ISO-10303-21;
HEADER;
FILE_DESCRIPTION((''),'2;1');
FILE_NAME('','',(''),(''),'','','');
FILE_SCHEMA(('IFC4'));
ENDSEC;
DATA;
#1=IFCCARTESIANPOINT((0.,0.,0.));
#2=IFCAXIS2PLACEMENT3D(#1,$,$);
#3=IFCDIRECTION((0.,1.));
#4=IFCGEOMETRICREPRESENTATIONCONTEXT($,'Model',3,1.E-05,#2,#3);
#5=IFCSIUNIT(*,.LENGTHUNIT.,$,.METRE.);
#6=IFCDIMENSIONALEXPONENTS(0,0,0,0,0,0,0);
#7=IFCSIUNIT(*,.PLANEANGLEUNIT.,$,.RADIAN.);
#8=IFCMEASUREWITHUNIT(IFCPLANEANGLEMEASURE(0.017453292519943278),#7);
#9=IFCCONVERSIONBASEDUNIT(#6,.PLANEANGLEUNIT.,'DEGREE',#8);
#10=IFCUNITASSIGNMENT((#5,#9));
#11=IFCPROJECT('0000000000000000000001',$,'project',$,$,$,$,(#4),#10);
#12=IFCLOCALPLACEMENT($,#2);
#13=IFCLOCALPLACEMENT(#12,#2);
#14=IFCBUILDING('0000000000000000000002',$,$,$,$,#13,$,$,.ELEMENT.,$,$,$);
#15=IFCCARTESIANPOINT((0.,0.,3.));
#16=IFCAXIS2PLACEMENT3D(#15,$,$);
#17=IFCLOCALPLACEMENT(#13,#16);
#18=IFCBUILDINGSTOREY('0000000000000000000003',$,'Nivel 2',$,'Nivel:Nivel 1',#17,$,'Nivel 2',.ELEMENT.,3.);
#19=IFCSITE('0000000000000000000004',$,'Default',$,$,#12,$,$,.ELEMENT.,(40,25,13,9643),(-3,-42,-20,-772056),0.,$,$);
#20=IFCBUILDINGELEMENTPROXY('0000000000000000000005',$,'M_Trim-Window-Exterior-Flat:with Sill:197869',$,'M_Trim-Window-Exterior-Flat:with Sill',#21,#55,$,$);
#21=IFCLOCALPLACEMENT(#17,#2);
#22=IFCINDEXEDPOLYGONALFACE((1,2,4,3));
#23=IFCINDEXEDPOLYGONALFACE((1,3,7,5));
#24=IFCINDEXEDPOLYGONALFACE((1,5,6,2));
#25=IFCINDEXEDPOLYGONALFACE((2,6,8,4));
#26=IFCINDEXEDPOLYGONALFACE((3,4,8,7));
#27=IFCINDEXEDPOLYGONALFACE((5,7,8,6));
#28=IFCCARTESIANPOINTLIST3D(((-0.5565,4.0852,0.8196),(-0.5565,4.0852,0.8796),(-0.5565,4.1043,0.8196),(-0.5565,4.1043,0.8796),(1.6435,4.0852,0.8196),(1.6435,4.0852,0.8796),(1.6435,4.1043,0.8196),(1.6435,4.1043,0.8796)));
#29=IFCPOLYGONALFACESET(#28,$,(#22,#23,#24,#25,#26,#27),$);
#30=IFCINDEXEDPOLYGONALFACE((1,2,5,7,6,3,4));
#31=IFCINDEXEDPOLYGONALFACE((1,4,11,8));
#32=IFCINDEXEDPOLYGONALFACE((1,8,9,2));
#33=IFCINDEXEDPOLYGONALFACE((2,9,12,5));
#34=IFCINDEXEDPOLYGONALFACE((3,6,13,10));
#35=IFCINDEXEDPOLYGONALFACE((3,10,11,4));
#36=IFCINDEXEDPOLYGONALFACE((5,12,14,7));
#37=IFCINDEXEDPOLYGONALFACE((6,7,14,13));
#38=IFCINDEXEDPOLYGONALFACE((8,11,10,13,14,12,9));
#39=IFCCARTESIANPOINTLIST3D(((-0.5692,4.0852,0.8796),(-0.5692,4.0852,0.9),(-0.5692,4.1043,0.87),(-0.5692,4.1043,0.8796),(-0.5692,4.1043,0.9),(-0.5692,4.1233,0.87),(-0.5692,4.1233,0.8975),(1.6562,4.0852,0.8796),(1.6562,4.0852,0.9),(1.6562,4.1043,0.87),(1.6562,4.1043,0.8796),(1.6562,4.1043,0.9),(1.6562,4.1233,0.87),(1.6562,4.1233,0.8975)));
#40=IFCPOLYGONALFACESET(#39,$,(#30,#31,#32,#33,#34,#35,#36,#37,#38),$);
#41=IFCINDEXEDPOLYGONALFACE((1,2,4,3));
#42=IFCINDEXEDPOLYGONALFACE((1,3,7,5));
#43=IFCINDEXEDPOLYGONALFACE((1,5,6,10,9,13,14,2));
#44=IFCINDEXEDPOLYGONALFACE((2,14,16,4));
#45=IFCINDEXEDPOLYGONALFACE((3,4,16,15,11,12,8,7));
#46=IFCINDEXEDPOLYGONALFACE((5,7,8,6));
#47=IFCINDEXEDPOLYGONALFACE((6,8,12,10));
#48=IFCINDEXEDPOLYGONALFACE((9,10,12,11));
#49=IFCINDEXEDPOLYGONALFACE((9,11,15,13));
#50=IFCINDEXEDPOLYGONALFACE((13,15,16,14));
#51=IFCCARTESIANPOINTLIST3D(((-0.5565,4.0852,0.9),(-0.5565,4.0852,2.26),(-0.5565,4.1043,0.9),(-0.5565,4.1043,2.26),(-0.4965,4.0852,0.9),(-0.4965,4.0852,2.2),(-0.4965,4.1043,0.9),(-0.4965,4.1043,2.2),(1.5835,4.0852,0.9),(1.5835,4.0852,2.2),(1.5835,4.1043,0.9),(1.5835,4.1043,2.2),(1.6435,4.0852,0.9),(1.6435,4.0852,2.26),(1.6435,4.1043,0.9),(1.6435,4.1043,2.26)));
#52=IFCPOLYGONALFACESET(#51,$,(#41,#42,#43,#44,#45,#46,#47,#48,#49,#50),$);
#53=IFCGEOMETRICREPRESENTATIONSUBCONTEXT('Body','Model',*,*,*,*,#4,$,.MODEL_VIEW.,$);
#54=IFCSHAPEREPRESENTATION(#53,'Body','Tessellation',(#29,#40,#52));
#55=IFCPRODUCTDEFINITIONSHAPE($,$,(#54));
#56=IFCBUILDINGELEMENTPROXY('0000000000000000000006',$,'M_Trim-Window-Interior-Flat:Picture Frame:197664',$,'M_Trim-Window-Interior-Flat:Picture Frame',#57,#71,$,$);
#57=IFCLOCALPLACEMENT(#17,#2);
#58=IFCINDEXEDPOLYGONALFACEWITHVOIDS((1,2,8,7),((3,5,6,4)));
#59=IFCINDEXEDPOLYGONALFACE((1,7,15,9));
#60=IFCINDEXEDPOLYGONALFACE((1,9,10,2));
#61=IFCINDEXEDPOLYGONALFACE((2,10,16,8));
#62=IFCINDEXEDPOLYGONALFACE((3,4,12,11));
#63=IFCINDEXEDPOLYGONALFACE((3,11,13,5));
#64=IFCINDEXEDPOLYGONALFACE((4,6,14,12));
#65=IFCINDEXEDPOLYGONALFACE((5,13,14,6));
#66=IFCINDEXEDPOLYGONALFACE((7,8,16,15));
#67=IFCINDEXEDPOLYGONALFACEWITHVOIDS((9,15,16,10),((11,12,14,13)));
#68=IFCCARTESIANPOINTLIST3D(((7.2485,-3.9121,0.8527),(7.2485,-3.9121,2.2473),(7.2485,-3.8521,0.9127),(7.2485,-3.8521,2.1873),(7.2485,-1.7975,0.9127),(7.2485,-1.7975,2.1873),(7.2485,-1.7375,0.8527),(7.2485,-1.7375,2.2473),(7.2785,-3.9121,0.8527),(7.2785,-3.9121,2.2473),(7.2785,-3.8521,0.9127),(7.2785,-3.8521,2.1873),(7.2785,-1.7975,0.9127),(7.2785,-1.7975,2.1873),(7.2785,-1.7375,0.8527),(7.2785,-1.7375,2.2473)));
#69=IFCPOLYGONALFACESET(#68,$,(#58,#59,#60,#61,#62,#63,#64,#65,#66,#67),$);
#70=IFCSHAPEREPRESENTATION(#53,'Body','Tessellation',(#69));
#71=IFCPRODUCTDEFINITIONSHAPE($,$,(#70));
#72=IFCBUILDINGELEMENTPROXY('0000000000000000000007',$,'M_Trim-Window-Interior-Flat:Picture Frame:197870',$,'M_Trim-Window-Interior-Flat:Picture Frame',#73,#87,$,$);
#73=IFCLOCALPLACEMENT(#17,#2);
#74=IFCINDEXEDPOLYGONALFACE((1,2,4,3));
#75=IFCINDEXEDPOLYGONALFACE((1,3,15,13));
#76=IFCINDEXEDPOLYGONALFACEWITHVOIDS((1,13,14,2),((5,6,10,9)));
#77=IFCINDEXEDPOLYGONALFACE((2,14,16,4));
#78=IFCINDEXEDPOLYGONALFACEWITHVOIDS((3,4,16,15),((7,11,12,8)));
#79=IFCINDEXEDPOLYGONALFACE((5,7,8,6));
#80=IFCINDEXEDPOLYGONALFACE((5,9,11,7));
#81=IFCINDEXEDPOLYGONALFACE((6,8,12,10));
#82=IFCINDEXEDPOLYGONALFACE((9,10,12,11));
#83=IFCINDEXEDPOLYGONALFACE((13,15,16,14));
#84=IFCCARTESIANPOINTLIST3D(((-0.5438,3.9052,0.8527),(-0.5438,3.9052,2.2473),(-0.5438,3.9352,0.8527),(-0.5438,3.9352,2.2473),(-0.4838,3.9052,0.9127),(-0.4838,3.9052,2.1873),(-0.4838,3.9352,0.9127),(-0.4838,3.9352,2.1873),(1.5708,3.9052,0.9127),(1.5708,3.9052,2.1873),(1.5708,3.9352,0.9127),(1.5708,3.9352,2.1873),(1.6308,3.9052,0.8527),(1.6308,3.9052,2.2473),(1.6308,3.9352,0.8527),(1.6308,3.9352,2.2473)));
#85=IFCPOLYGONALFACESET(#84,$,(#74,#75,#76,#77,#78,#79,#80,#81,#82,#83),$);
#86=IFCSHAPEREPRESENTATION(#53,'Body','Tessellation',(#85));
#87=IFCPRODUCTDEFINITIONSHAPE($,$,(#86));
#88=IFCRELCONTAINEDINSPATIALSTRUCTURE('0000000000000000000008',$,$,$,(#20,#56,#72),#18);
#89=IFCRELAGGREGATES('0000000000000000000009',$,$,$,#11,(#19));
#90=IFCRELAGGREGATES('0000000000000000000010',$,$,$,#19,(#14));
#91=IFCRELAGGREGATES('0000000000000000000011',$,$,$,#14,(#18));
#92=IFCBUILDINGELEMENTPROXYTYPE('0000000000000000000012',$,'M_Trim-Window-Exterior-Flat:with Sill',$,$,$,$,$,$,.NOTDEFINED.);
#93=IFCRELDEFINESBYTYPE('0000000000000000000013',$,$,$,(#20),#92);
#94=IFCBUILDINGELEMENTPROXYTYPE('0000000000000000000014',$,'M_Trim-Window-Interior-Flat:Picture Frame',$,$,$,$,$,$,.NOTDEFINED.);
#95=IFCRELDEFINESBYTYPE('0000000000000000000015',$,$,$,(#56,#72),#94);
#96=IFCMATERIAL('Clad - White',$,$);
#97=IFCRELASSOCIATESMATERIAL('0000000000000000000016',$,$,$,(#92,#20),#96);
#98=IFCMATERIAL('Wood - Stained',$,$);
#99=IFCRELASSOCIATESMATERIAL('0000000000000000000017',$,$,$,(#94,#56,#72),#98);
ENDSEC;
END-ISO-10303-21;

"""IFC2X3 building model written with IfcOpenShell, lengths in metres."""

from ifc_helpers import new_model, entity, si_unit, converted_unit, direction, frame, frame_2d, origin, place, context, subcontext, project, spatial, polyline, rectangle, outline, extrude, source, transform, mapped, material, type_object, type_shapes, element, save


model = new_model("IFC2X3")

# Units and contexts
model_context = context("Model", 3, precision=1e-05, world=origin(), true_north=direction((0.0, 1.0)))
body_context = subcontext(model_context, "Body", "Model", "MODEL_VIEW")
ifc_project = project(units=[si_unit("LENGTHUNIT", "METRE"), converted_unit("PLANEANGLEUNIT", "DEGREE", entity("IfcPlaneAngleMeasure", 0.017453292519943278), si_unit("PLANEANGLEUNIT", "RADIAN"), dimensions=[0, 0, 0, 0, 0, 0, 0])], contexts=[model_context])

# Site, building, storey
site_placement = place(None, origin())
site = spatial("IfcSite", under=ifc_project, at=site_placement, Name="Default", CompositionType="ELEMENT", RefLatitude=(40, 25, 13, 9643), RefLongitude=(-3, -42, -20, -772056), RefElevation=0.0)
building_placement = place(site_placement, origin())
building = spatial("IfcBuilding", under=site, at=building_placement, CompositionType="ELEMENT")
storey_placement = place(building_placement, frame((0.0, 0.0, 3.0)))
storey = spatial("IfcBuildingStorey", under=building, at=storey_placement, Name="Nivel 2", ObjectType="Nivel:Nivel 1", LongName="Nivel 2", CompositionType="ELEMENT", Elevation=3.0)

# Building element proxies
ifc_material_1 = material(Name="Clad - White")
ifc_material_2 = material(Name="Wood - Stained")
building_element_proxy_type_1 = type_object("IfcBuildingElementProxyType", Name="M_Trim-Window-Exterior-Flat:with Sill", PredefinedType="NOTDEFINED", material=ifc_material_1)
shared_shape_1 = source(origin(), body_context, "Body", "SweptSolid", [
    extrude(rectangle(XDim=2.2, YDim=0.06, at=frame_2d((0.0, 0.0), x_axis=(1.0, 0.0))), frame((0.0, -1.3504, 0.0), z_axis=(0.0, 0.0, 1.0), x_axis=(-1.0, 0.0, 0.0)), (0.0, 0.0, 1.0), 0.019),
    extrude(outline(polyline([(-0.019, -0.0152), (0.0, -0.0152), (0.0, -0.0057), (0.019, -0.0057), (0.019, 0.0148), (0.0, 0.0148), (-0.019, 0.0123), (-0.019, -0.0152)])), frame((-1.1127, -1.3148, 0.019), z_axis=(1.0, 0.0, 0.0), x_axis=(0.0, 0.0, -1.0)), (0.0, 0.0, 1.0), 2.2254),
    extrude(outline(polyline([(-0.695, -1.1), (0.665, -1.1), (0.665, -1.04), (-0.635, -1.04), (-0.635, 1.04), (0.665, 1.04), (0.665, 1.1), (-0.695, 1.1), (-0.695, -1.1)])), frame((0.0, -0.635, 0.0), z_axis=(0.0, 0.0, 1.0), x_axis=(0.0, -1.0, 0.0)), (0.0, 0.0, 1.0), 0.019),
])
type_shapes(building_element_proxy_type_1, [shared_shape_1])
for number, where, z_axis, x_axis, name in (
    (1, (0.5435, 4.0852, 2.2), (0.0, 1.0, 0.0), (-1.0, 0.0, 0.0), "M_Trim-Window-Exterior-Flat:with Sill:197869"),
):
    element("IfcBuildingElementProxy", number, at=place(storey_placement, frame(where, z_axis=z_axis, x_axis=x_axis)), inside=storey, type_object=building_element_proxy_type_1, material=ifc_material_1, Name=name, ObjectType="M_Trim-Window-Exterior-Flat:with Sill", context=body_context, shape_type="MappedRepresentation", body=[
        mapped(shared_shape_1, transform((0.0, 0.0, 0.0), scale=1.0)),
    ])
building_element_proxy_type_2 = type_object("IfcBuildingElementProxyType", Name="M_Trim-Window-Interior-Flat:Picture Frame", PredefinedType="NOTDEFINED", material=ifc_material_2)
shared_shape_2 = source(origin(), body_context, "Body", "SweptSolid", [
    extrude(outline(polyline([(-1.0873, -0.6973), (1.0873, -0.6973), (1.0873, 0.6973), (-1.0873, 0.6973), (-1.0873, -0.6973)]), holes=[polyline([(-1.0273, -0.6373), (-1.0273, 0.6373), (1.0273, 0.6373), (1.0273, -0.6373), (-1.0273, -0.6373)])]), frame((0.0, -0.65, 0.0), z_axis=(0.0, 0.0, 1.0), x_axis=(-1.0, 0.0, 0.0)), (0.0, 0.0, 1.0), 0.03),
])
type_shapes(building_element_proxy_type_2, [shared_shape_2])
for number, where, z_axis, x_axis, name in (
    (2, (7.2785, -2.8248, 2.2), (-1.0, 0.0, 0.0), (0.0, -1.0, 0.0), "M_Trim-Window-Interior-Flat:Picture Frame:197664"),
    (3, (0.5435, 3.9352, 2.2), (0.0, -1.0, 0.0), (1.0, 0.0, 0.0), "M_Trim-Window-Interior-Flat:Picture Frame:197870"),
):
    element("IfcBuildingElementProxy", number, at=place(storey_placement, frame(where, z_axis=z_axis, x_axis=x_axis)), inside=storey, type_object=building_element_proxy_type_2, material=ifc_material_2, Name=name, ObjectType="M_Trim-Window-Interior-Flat:Picture Frame", context=body_context, shape_type="MappedRepresentation", body=[
        mapped(shared_shape_2, transform((0.0, 0.0, 0.0), scale=1.0)),
    ])

save(model, "model.ifc")
